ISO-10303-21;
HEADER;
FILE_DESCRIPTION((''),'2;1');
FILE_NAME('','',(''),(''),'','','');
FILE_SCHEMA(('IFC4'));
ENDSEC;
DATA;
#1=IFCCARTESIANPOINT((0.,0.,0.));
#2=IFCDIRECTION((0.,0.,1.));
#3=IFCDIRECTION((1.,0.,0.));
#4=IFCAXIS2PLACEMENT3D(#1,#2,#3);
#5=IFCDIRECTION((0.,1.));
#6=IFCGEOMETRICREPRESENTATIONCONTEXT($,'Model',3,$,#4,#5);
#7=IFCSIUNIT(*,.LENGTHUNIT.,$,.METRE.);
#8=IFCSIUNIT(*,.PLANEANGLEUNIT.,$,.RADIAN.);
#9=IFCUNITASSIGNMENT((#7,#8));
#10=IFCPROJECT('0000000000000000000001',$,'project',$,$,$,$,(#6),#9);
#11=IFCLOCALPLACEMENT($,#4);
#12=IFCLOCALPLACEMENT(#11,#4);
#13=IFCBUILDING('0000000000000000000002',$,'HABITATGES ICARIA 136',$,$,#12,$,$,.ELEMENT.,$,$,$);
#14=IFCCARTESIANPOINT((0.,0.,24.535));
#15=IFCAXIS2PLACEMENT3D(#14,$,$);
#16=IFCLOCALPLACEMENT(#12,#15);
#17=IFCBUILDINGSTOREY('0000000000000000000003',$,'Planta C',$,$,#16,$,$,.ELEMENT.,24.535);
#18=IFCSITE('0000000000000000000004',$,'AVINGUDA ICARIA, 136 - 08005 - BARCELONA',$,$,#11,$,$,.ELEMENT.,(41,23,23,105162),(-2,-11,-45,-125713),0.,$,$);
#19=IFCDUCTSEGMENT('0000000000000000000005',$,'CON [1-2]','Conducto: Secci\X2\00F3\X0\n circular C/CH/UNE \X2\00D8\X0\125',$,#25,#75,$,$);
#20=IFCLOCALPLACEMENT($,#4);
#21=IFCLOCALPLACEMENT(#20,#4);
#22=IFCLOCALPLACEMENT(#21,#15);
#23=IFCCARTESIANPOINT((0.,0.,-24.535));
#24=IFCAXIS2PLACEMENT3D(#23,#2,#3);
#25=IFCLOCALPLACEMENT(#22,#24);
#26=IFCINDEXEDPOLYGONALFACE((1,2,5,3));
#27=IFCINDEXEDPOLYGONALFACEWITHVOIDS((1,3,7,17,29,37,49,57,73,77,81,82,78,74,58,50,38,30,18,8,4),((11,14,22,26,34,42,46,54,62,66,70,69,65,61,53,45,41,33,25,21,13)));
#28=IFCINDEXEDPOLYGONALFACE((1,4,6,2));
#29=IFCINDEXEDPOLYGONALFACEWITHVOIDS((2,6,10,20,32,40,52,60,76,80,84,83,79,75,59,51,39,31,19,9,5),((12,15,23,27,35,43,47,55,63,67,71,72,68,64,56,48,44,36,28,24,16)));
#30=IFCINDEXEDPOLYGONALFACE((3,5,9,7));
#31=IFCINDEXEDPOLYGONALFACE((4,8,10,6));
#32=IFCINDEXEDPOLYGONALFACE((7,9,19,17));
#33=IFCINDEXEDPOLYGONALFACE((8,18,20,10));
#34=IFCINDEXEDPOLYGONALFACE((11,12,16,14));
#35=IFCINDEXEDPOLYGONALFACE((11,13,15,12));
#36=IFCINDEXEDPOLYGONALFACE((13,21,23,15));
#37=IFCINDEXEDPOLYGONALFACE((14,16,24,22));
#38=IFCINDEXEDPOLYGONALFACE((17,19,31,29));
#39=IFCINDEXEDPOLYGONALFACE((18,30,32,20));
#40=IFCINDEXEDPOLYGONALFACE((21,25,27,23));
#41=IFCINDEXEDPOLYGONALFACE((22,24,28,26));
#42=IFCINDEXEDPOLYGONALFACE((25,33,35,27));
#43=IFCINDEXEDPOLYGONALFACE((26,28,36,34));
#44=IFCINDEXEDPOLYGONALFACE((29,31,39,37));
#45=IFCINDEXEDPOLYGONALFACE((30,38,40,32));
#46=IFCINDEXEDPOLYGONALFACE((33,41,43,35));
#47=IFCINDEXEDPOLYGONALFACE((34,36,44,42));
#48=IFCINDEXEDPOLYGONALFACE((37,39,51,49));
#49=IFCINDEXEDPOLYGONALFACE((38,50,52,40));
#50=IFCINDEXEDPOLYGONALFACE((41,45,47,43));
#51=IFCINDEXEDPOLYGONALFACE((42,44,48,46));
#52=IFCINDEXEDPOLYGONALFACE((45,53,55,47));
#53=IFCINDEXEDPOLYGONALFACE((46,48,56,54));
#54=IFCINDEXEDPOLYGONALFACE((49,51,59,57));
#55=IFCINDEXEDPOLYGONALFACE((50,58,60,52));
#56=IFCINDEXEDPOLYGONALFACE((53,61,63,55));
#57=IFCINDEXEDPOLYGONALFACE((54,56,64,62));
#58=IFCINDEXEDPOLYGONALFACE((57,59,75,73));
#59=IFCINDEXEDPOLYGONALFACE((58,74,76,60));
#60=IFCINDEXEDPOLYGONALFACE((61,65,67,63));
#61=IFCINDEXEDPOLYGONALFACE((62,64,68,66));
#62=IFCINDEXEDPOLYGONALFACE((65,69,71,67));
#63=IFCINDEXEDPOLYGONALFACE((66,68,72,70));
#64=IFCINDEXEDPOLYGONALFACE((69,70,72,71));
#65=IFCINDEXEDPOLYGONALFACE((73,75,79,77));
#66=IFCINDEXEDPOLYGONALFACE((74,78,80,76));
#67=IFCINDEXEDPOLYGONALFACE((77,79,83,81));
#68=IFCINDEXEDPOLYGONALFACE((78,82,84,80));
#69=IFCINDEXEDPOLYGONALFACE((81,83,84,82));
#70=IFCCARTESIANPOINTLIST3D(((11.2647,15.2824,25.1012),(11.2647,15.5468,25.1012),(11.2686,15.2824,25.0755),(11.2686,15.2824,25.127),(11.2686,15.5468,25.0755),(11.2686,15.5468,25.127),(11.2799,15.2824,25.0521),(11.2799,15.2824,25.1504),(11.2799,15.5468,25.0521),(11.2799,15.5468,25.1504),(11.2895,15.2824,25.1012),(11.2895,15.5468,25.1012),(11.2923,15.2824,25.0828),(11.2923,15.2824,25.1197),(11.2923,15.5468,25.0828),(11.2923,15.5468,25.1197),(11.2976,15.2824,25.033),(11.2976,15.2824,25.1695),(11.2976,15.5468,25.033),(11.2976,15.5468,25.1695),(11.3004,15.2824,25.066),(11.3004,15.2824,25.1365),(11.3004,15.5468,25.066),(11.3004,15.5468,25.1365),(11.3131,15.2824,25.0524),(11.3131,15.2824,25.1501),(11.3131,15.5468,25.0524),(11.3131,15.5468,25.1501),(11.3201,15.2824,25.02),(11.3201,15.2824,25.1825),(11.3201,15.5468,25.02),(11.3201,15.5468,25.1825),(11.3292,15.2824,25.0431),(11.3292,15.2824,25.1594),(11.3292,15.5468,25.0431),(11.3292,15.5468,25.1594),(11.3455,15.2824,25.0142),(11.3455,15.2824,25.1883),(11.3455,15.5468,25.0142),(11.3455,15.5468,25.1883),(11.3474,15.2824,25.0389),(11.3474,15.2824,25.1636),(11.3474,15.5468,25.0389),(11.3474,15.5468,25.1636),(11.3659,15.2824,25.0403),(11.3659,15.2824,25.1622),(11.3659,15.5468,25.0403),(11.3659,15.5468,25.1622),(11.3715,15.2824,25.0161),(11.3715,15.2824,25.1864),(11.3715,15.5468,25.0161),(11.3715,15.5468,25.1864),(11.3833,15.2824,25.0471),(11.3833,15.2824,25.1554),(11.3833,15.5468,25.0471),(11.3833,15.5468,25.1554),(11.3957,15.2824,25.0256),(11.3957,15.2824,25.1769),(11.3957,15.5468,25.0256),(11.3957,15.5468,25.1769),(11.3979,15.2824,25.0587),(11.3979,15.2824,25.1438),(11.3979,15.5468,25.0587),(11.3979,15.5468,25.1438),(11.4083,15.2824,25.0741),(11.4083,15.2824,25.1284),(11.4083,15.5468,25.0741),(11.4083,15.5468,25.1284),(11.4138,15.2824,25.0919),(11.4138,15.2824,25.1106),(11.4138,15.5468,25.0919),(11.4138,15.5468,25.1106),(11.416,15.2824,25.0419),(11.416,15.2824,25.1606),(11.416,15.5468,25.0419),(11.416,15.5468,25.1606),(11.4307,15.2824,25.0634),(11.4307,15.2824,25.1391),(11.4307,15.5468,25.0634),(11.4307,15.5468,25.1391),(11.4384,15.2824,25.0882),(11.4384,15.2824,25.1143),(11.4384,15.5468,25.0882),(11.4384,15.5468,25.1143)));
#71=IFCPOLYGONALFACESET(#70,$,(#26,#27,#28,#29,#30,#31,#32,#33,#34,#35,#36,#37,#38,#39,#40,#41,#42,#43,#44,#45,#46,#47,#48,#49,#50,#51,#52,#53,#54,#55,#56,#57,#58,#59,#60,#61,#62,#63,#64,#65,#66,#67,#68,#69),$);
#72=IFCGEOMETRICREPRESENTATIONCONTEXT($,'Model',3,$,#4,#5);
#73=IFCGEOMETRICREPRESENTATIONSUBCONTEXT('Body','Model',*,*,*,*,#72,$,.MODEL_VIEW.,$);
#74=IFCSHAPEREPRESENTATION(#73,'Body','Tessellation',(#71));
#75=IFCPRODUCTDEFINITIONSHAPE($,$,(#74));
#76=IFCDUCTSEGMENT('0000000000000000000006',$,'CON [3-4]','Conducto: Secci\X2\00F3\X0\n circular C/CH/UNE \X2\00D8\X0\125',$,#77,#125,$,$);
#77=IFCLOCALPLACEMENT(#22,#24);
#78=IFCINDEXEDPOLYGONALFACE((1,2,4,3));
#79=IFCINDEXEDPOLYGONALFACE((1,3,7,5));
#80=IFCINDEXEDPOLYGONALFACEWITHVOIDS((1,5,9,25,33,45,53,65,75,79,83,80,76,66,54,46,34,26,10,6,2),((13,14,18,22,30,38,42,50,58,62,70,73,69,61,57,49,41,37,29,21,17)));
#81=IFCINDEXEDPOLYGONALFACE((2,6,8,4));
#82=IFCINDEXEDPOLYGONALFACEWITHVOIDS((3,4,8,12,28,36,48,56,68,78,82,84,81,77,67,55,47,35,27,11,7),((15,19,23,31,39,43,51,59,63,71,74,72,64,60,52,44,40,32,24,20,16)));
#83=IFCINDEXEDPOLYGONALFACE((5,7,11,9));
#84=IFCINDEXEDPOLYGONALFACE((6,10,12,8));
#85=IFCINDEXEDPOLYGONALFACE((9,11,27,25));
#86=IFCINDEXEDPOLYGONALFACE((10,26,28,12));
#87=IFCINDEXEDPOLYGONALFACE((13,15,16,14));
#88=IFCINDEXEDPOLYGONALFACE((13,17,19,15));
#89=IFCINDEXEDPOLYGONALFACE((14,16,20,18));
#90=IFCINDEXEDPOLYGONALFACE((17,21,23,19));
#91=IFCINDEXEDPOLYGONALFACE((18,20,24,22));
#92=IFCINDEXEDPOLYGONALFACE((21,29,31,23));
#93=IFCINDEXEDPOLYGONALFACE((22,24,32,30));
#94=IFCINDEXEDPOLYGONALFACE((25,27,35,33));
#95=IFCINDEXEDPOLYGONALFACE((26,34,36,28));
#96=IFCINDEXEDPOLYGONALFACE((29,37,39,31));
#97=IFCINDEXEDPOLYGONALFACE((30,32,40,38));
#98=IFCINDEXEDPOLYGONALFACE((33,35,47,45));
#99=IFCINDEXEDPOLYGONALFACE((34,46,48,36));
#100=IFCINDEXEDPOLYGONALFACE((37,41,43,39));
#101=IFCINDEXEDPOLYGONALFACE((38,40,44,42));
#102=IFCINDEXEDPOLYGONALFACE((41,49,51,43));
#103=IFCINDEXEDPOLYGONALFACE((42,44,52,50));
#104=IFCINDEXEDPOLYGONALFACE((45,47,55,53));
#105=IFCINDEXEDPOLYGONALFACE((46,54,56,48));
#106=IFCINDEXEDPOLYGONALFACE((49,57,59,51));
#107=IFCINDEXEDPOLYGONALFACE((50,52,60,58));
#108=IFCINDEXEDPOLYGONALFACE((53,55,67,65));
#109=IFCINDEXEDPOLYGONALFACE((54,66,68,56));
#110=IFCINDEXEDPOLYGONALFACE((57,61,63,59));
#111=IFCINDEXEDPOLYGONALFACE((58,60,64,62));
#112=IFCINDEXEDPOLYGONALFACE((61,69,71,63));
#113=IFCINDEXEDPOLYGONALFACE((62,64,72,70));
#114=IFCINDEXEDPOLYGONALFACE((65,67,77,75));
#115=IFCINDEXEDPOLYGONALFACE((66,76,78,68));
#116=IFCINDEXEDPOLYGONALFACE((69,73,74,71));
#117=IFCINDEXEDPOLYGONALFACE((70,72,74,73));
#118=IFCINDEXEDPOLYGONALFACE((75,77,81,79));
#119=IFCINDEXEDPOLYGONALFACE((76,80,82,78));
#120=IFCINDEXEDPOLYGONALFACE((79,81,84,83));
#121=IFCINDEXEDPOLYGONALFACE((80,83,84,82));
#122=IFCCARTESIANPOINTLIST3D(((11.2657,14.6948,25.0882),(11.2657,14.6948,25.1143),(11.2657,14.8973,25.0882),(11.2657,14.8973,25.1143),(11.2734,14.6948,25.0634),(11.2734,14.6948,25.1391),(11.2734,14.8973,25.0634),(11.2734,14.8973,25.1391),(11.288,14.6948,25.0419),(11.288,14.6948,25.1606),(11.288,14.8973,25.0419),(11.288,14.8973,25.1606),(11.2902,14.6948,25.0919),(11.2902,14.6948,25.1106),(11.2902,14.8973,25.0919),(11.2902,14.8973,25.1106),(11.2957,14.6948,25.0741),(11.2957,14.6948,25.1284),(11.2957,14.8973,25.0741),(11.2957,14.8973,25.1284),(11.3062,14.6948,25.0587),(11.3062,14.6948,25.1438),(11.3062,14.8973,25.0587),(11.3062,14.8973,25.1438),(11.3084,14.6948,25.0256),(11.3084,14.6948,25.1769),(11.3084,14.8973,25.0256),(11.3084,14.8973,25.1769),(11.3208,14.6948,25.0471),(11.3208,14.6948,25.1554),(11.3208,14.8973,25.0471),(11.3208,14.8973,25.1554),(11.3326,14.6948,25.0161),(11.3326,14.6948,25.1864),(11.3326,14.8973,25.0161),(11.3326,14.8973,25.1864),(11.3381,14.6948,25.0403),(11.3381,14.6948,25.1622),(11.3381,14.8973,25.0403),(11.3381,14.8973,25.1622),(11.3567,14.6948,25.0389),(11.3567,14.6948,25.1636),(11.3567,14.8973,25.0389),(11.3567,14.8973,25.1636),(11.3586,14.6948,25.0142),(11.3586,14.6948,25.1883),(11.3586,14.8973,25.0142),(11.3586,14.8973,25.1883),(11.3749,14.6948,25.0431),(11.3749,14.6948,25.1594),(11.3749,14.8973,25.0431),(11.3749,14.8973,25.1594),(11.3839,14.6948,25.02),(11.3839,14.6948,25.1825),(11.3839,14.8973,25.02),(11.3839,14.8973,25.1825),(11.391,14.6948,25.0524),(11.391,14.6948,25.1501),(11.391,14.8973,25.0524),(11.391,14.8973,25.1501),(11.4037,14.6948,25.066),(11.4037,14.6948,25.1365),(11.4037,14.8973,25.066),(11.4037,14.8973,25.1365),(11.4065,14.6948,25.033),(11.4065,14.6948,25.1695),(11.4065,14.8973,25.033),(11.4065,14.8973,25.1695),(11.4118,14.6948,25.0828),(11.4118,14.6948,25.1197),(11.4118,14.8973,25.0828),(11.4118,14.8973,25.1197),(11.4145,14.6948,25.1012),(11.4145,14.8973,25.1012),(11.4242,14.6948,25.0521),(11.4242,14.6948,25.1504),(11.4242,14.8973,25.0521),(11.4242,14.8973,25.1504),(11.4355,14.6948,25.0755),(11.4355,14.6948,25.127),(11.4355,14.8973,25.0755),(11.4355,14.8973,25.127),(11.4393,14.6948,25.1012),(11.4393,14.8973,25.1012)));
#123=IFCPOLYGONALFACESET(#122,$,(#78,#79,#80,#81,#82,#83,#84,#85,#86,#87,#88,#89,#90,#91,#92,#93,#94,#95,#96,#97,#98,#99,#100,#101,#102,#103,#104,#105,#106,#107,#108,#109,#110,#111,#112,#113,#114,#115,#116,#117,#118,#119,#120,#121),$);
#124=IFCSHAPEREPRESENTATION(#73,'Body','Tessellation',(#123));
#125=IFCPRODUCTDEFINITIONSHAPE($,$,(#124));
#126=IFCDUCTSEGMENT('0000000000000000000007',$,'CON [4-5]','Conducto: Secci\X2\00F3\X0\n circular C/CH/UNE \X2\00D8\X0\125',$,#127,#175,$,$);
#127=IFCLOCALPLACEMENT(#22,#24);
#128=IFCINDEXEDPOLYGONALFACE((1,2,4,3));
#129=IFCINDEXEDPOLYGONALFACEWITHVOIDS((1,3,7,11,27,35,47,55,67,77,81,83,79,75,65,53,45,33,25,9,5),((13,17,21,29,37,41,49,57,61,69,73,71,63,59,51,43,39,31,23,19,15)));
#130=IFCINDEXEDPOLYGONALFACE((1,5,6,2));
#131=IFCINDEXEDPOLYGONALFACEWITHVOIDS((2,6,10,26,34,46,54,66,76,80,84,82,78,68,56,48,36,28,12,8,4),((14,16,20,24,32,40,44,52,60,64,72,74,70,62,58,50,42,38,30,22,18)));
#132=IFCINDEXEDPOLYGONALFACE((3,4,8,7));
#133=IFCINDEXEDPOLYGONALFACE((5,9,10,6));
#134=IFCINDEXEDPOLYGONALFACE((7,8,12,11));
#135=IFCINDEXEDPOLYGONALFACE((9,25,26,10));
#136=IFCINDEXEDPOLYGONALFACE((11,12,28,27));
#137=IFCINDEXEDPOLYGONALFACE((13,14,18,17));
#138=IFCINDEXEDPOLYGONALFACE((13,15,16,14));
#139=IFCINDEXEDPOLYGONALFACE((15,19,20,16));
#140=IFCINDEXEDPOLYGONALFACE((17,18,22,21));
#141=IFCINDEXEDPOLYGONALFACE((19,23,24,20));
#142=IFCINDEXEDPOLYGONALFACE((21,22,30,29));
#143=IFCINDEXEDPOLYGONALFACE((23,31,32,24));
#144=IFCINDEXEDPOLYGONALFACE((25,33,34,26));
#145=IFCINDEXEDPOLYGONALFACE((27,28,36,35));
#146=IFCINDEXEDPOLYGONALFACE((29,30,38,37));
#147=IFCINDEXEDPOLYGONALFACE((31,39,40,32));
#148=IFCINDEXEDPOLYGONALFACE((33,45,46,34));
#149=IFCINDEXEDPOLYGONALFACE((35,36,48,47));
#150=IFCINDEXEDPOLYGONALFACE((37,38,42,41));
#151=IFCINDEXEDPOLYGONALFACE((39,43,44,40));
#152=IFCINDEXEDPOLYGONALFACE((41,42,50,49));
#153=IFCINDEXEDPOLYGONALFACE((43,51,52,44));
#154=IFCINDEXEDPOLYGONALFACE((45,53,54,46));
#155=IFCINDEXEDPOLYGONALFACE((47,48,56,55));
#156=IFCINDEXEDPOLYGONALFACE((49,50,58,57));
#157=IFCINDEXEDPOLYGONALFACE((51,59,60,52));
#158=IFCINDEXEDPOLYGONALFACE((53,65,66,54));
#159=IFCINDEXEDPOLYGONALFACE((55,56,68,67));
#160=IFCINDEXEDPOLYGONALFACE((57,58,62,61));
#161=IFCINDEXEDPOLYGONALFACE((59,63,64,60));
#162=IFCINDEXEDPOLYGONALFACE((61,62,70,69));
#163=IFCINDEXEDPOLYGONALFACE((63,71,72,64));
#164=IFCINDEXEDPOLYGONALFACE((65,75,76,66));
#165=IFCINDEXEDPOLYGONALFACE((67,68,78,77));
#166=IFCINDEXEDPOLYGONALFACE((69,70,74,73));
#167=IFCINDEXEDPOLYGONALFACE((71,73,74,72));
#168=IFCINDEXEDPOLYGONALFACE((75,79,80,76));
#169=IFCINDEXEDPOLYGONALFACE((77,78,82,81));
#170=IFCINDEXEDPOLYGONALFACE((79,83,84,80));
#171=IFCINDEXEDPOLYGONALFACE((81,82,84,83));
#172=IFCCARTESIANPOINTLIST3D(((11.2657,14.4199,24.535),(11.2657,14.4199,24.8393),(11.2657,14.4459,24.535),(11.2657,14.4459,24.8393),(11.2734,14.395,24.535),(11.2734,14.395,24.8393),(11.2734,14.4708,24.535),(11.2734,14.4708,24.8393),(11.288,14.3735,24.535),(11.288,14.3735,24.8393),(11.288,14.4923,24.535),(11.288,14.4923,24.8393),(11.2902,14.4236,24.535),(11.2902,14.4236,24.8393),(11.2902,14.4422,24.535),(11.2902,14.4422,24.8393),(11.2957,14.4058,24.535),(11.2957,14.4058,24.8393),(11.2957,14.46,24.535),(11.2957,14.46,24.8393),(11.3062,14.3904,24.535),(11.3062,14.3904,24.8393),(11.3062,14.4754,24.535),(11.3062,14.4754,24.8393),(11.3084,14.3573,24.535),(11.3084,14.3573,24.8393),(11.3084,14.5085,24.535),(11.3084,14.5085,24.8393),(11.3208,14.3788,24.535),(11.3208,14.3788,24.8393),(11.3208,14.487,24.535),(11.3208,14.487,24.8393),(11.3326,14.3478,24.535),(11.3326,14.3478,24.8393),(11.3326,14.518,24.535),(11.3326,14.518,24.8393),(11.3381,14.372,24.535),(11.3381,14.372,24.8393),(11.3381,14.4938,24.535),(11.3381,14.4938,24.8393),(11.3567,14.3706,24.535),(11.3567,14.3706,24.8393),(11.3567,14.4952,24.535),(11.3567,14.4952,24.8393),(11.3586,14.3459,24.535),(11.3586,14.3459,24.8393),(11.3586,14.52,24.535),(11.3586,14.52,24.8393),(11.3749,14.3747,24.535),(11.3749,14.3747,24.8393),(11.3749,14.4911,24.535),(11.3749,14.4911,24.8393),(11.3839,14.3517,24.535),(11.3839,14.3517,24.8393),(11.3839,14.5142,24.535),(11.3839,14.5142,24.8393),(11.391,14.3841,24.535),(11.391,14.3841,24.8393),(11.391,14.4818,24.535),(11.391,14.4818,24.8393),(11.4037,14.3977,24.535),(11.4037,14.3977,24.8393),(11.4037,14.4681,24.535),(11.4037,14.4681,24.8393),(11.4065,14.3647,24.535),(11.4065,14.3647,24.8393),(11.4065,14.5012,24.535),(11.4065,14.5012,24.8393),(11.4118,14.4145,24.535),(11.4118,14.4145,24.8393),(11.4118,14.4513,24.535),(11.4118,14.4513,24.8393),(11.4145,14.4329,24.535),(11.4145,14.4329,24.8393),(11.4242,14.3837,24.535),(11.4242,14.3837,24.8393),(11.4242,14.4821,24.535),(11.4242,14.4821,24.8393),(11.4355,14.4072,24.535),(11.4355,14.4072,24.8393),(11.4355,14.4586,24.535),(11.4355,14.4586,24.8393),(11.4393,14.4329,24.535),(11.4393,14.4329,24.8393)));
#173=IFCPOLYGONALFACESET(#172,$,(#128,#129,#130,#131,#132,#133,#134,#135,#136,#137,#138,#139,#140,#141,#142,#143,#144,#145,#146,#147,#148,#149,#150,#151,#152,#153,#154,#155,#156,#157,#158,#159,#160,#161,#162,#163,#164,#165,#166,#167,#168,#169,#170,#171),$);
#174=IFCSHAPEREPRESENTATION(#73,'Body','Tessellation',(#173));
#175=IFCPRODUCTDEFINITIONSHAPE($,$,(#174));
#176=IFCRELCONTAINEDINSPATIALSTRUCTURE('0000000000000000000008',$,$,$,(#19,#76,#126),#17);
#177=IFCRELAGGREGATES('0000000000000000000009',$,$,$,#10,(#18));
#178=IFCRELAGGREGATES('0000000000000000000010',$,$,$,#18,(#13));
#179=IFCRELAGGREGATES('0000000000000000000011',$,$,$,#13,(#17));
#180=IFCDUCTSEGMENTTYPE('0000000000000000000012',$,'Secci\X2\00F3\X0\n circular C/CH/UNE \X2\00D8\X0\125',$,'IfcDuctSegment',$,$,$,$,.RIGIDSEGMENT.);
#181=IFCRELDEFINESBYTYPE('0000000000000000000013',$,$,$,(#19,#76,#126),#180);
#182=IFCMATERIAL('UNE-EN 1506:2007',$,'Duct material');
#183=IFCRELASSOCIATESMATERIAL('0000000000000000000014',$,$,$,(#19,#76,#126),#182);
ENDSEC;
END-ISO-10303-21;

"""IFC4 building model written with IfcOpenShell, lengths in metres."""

from ifc_helpers import new_model, si_unit, direction, frame, origin_with_axes, origin_2d_with_axis, place, context, subcontext, project, spatial, hollow_circle, extrude, material, type_object, element, save


model = new_model("IFC4")

# Units and contexts
model_context_1 = context("Model", 3, world=origin_with_axes(), true_north=direction((0.0, 1.0)))
model_context_2 = context("Model", 3, world=origin_with_axes(), true_north=direction((0.0, 1.0)))
body_context = subcontext(model_context_2, "Body", "Model", "MODEL_VIEW")
ifc_project = project(units=[si_unit("LENGTHUNIT", "METRE"), si_unit("PLANEANGLEUNIT", "RADIAN")], contexts=[model_context_1])

# Site, building, storey
site_placement = place(None, origin_with_axes())
site = spatial("IfcSite", under=ifc_project, at=site_placement, Name="AVINGUDA ICARIA, 136 - 08005 - BARCELONA", CompositionType="ELEMENT", RefLatitude=(41, 23, 23, 105162), RefLongitude=(-2, -11, -45, -125713), RefElevation=0.0)
building_placement = place(site_placement, origin_with_axes())
building = spatial("IfcBuilding", under=site, at=building_placement, Name="HABITATGES ICARIA 136", CompositionType="ELEMENT")
storey_placement = place(building_placement, frame((0.0, 0.0, 24.535)))
storey = spatial("IfcBuildingStorey", under=building, at=storey_placement, Name="Planta C", CompositionType="ELEMENT", Elevation=24.535)

# Duct segments
ifc_material = material(Name="UNE-EN 1506:2007", Category="Duct material")
duct_segment_type = type_object("IfcDuctSegmentType", Name="Sección circular C/CH/UNE Ø125", ApplicableOccurrence="IfcDuctSegment", PredefinedType="RIGIDSEGMENT")
placement_1 = place(None, origin_with_axes())
placement_2 = place(placement_1, origin_with_axes())
placement_3 = place(placement_2, frame((0.0, 0.0, 24.535)))
duct_segment_1_placement = place(placement_3, frame((0.0, 0.0, -24.535), z_axis=(0.0, 0.0, 1.0), x_axis=(1.0, 0.0, 0.0)))
element("IfcDuctSegment", 1, at=duct_segment_1_placement, inside=storey, type_object=duct_segment_type, material=ifc_material, Name="CON [1-2]", Description="Conducto: Sección circular C/CH/UNE Ø125", context=body_context, shape_type="SweptSolid", body=[
    extrude(hollow_circle(Radius=0.0873, WallThickness=0.0248, at=origin_2d_with_axis()), frame((11.352, 15.2824, 25.1012), z_axis=(0.0, 1.0, 0.0), x_axis=(-1.0, 0.0, 0.0)), (0.0, 0.0, 1.0), 0.2644),
])
duct_segment_2_placement = place(placement_3, frame((0.0, 0.0, -24.535), z_axis=(0.0, 0.0, 1.0), x_axis=(1.0, 0.0, 0.0)))
element("IfcDuctSegment", 2, at=duct_segment_2_placement, inside=storey, type_object=duct_segment_type, material=ifc_material, Name="CON [3-4]", Description="Conducto: Sección circular C/CH/UNE Ø125", context=body_context, shape_type="SweptSolid", body=[
    extrude(hollow_circle(Radius=0.0873, WallThickness=0.0248, at=origin_2d_with_axis()), frame((11.352, 14.8973, 25.1012), z_axis=(0.0, -1.0, 0.0), x_axis=(1.0, 0.0, 0.0)), (0.0, 0.0, 1.0), 0.2025),
])
duct_segment_3_placement = place(placement_3, frame((0.0, 0.0, -24.535), z_axis=(0.0, 0.0, 1.0), x_axis=(1.0, 0.0, 0.0)))
element("IfcDuctSegment", 3, at=duct_segment_3_placement, inside=storey, type_object=duct_segment_type, material=ifc_material, Name="CON [4-5]", Description="Conducto: Sección circular C/CH/UNE Ø125", context=body_context, shape_type="SweptSolid", body=[
    extrude(hollow_circle(Radius=0.0873, WallThickness=0.0248, at=origin_2d_with_axis()), frame((11.352, 14.4329, 24.8393), z_axis=(0.0, 0.0, -1.0), x_axis=(1.0, 0.0, 0.0)), (0.0, 0.0, 1.0), 0.3043),
])

save(model, "model.ifc")
